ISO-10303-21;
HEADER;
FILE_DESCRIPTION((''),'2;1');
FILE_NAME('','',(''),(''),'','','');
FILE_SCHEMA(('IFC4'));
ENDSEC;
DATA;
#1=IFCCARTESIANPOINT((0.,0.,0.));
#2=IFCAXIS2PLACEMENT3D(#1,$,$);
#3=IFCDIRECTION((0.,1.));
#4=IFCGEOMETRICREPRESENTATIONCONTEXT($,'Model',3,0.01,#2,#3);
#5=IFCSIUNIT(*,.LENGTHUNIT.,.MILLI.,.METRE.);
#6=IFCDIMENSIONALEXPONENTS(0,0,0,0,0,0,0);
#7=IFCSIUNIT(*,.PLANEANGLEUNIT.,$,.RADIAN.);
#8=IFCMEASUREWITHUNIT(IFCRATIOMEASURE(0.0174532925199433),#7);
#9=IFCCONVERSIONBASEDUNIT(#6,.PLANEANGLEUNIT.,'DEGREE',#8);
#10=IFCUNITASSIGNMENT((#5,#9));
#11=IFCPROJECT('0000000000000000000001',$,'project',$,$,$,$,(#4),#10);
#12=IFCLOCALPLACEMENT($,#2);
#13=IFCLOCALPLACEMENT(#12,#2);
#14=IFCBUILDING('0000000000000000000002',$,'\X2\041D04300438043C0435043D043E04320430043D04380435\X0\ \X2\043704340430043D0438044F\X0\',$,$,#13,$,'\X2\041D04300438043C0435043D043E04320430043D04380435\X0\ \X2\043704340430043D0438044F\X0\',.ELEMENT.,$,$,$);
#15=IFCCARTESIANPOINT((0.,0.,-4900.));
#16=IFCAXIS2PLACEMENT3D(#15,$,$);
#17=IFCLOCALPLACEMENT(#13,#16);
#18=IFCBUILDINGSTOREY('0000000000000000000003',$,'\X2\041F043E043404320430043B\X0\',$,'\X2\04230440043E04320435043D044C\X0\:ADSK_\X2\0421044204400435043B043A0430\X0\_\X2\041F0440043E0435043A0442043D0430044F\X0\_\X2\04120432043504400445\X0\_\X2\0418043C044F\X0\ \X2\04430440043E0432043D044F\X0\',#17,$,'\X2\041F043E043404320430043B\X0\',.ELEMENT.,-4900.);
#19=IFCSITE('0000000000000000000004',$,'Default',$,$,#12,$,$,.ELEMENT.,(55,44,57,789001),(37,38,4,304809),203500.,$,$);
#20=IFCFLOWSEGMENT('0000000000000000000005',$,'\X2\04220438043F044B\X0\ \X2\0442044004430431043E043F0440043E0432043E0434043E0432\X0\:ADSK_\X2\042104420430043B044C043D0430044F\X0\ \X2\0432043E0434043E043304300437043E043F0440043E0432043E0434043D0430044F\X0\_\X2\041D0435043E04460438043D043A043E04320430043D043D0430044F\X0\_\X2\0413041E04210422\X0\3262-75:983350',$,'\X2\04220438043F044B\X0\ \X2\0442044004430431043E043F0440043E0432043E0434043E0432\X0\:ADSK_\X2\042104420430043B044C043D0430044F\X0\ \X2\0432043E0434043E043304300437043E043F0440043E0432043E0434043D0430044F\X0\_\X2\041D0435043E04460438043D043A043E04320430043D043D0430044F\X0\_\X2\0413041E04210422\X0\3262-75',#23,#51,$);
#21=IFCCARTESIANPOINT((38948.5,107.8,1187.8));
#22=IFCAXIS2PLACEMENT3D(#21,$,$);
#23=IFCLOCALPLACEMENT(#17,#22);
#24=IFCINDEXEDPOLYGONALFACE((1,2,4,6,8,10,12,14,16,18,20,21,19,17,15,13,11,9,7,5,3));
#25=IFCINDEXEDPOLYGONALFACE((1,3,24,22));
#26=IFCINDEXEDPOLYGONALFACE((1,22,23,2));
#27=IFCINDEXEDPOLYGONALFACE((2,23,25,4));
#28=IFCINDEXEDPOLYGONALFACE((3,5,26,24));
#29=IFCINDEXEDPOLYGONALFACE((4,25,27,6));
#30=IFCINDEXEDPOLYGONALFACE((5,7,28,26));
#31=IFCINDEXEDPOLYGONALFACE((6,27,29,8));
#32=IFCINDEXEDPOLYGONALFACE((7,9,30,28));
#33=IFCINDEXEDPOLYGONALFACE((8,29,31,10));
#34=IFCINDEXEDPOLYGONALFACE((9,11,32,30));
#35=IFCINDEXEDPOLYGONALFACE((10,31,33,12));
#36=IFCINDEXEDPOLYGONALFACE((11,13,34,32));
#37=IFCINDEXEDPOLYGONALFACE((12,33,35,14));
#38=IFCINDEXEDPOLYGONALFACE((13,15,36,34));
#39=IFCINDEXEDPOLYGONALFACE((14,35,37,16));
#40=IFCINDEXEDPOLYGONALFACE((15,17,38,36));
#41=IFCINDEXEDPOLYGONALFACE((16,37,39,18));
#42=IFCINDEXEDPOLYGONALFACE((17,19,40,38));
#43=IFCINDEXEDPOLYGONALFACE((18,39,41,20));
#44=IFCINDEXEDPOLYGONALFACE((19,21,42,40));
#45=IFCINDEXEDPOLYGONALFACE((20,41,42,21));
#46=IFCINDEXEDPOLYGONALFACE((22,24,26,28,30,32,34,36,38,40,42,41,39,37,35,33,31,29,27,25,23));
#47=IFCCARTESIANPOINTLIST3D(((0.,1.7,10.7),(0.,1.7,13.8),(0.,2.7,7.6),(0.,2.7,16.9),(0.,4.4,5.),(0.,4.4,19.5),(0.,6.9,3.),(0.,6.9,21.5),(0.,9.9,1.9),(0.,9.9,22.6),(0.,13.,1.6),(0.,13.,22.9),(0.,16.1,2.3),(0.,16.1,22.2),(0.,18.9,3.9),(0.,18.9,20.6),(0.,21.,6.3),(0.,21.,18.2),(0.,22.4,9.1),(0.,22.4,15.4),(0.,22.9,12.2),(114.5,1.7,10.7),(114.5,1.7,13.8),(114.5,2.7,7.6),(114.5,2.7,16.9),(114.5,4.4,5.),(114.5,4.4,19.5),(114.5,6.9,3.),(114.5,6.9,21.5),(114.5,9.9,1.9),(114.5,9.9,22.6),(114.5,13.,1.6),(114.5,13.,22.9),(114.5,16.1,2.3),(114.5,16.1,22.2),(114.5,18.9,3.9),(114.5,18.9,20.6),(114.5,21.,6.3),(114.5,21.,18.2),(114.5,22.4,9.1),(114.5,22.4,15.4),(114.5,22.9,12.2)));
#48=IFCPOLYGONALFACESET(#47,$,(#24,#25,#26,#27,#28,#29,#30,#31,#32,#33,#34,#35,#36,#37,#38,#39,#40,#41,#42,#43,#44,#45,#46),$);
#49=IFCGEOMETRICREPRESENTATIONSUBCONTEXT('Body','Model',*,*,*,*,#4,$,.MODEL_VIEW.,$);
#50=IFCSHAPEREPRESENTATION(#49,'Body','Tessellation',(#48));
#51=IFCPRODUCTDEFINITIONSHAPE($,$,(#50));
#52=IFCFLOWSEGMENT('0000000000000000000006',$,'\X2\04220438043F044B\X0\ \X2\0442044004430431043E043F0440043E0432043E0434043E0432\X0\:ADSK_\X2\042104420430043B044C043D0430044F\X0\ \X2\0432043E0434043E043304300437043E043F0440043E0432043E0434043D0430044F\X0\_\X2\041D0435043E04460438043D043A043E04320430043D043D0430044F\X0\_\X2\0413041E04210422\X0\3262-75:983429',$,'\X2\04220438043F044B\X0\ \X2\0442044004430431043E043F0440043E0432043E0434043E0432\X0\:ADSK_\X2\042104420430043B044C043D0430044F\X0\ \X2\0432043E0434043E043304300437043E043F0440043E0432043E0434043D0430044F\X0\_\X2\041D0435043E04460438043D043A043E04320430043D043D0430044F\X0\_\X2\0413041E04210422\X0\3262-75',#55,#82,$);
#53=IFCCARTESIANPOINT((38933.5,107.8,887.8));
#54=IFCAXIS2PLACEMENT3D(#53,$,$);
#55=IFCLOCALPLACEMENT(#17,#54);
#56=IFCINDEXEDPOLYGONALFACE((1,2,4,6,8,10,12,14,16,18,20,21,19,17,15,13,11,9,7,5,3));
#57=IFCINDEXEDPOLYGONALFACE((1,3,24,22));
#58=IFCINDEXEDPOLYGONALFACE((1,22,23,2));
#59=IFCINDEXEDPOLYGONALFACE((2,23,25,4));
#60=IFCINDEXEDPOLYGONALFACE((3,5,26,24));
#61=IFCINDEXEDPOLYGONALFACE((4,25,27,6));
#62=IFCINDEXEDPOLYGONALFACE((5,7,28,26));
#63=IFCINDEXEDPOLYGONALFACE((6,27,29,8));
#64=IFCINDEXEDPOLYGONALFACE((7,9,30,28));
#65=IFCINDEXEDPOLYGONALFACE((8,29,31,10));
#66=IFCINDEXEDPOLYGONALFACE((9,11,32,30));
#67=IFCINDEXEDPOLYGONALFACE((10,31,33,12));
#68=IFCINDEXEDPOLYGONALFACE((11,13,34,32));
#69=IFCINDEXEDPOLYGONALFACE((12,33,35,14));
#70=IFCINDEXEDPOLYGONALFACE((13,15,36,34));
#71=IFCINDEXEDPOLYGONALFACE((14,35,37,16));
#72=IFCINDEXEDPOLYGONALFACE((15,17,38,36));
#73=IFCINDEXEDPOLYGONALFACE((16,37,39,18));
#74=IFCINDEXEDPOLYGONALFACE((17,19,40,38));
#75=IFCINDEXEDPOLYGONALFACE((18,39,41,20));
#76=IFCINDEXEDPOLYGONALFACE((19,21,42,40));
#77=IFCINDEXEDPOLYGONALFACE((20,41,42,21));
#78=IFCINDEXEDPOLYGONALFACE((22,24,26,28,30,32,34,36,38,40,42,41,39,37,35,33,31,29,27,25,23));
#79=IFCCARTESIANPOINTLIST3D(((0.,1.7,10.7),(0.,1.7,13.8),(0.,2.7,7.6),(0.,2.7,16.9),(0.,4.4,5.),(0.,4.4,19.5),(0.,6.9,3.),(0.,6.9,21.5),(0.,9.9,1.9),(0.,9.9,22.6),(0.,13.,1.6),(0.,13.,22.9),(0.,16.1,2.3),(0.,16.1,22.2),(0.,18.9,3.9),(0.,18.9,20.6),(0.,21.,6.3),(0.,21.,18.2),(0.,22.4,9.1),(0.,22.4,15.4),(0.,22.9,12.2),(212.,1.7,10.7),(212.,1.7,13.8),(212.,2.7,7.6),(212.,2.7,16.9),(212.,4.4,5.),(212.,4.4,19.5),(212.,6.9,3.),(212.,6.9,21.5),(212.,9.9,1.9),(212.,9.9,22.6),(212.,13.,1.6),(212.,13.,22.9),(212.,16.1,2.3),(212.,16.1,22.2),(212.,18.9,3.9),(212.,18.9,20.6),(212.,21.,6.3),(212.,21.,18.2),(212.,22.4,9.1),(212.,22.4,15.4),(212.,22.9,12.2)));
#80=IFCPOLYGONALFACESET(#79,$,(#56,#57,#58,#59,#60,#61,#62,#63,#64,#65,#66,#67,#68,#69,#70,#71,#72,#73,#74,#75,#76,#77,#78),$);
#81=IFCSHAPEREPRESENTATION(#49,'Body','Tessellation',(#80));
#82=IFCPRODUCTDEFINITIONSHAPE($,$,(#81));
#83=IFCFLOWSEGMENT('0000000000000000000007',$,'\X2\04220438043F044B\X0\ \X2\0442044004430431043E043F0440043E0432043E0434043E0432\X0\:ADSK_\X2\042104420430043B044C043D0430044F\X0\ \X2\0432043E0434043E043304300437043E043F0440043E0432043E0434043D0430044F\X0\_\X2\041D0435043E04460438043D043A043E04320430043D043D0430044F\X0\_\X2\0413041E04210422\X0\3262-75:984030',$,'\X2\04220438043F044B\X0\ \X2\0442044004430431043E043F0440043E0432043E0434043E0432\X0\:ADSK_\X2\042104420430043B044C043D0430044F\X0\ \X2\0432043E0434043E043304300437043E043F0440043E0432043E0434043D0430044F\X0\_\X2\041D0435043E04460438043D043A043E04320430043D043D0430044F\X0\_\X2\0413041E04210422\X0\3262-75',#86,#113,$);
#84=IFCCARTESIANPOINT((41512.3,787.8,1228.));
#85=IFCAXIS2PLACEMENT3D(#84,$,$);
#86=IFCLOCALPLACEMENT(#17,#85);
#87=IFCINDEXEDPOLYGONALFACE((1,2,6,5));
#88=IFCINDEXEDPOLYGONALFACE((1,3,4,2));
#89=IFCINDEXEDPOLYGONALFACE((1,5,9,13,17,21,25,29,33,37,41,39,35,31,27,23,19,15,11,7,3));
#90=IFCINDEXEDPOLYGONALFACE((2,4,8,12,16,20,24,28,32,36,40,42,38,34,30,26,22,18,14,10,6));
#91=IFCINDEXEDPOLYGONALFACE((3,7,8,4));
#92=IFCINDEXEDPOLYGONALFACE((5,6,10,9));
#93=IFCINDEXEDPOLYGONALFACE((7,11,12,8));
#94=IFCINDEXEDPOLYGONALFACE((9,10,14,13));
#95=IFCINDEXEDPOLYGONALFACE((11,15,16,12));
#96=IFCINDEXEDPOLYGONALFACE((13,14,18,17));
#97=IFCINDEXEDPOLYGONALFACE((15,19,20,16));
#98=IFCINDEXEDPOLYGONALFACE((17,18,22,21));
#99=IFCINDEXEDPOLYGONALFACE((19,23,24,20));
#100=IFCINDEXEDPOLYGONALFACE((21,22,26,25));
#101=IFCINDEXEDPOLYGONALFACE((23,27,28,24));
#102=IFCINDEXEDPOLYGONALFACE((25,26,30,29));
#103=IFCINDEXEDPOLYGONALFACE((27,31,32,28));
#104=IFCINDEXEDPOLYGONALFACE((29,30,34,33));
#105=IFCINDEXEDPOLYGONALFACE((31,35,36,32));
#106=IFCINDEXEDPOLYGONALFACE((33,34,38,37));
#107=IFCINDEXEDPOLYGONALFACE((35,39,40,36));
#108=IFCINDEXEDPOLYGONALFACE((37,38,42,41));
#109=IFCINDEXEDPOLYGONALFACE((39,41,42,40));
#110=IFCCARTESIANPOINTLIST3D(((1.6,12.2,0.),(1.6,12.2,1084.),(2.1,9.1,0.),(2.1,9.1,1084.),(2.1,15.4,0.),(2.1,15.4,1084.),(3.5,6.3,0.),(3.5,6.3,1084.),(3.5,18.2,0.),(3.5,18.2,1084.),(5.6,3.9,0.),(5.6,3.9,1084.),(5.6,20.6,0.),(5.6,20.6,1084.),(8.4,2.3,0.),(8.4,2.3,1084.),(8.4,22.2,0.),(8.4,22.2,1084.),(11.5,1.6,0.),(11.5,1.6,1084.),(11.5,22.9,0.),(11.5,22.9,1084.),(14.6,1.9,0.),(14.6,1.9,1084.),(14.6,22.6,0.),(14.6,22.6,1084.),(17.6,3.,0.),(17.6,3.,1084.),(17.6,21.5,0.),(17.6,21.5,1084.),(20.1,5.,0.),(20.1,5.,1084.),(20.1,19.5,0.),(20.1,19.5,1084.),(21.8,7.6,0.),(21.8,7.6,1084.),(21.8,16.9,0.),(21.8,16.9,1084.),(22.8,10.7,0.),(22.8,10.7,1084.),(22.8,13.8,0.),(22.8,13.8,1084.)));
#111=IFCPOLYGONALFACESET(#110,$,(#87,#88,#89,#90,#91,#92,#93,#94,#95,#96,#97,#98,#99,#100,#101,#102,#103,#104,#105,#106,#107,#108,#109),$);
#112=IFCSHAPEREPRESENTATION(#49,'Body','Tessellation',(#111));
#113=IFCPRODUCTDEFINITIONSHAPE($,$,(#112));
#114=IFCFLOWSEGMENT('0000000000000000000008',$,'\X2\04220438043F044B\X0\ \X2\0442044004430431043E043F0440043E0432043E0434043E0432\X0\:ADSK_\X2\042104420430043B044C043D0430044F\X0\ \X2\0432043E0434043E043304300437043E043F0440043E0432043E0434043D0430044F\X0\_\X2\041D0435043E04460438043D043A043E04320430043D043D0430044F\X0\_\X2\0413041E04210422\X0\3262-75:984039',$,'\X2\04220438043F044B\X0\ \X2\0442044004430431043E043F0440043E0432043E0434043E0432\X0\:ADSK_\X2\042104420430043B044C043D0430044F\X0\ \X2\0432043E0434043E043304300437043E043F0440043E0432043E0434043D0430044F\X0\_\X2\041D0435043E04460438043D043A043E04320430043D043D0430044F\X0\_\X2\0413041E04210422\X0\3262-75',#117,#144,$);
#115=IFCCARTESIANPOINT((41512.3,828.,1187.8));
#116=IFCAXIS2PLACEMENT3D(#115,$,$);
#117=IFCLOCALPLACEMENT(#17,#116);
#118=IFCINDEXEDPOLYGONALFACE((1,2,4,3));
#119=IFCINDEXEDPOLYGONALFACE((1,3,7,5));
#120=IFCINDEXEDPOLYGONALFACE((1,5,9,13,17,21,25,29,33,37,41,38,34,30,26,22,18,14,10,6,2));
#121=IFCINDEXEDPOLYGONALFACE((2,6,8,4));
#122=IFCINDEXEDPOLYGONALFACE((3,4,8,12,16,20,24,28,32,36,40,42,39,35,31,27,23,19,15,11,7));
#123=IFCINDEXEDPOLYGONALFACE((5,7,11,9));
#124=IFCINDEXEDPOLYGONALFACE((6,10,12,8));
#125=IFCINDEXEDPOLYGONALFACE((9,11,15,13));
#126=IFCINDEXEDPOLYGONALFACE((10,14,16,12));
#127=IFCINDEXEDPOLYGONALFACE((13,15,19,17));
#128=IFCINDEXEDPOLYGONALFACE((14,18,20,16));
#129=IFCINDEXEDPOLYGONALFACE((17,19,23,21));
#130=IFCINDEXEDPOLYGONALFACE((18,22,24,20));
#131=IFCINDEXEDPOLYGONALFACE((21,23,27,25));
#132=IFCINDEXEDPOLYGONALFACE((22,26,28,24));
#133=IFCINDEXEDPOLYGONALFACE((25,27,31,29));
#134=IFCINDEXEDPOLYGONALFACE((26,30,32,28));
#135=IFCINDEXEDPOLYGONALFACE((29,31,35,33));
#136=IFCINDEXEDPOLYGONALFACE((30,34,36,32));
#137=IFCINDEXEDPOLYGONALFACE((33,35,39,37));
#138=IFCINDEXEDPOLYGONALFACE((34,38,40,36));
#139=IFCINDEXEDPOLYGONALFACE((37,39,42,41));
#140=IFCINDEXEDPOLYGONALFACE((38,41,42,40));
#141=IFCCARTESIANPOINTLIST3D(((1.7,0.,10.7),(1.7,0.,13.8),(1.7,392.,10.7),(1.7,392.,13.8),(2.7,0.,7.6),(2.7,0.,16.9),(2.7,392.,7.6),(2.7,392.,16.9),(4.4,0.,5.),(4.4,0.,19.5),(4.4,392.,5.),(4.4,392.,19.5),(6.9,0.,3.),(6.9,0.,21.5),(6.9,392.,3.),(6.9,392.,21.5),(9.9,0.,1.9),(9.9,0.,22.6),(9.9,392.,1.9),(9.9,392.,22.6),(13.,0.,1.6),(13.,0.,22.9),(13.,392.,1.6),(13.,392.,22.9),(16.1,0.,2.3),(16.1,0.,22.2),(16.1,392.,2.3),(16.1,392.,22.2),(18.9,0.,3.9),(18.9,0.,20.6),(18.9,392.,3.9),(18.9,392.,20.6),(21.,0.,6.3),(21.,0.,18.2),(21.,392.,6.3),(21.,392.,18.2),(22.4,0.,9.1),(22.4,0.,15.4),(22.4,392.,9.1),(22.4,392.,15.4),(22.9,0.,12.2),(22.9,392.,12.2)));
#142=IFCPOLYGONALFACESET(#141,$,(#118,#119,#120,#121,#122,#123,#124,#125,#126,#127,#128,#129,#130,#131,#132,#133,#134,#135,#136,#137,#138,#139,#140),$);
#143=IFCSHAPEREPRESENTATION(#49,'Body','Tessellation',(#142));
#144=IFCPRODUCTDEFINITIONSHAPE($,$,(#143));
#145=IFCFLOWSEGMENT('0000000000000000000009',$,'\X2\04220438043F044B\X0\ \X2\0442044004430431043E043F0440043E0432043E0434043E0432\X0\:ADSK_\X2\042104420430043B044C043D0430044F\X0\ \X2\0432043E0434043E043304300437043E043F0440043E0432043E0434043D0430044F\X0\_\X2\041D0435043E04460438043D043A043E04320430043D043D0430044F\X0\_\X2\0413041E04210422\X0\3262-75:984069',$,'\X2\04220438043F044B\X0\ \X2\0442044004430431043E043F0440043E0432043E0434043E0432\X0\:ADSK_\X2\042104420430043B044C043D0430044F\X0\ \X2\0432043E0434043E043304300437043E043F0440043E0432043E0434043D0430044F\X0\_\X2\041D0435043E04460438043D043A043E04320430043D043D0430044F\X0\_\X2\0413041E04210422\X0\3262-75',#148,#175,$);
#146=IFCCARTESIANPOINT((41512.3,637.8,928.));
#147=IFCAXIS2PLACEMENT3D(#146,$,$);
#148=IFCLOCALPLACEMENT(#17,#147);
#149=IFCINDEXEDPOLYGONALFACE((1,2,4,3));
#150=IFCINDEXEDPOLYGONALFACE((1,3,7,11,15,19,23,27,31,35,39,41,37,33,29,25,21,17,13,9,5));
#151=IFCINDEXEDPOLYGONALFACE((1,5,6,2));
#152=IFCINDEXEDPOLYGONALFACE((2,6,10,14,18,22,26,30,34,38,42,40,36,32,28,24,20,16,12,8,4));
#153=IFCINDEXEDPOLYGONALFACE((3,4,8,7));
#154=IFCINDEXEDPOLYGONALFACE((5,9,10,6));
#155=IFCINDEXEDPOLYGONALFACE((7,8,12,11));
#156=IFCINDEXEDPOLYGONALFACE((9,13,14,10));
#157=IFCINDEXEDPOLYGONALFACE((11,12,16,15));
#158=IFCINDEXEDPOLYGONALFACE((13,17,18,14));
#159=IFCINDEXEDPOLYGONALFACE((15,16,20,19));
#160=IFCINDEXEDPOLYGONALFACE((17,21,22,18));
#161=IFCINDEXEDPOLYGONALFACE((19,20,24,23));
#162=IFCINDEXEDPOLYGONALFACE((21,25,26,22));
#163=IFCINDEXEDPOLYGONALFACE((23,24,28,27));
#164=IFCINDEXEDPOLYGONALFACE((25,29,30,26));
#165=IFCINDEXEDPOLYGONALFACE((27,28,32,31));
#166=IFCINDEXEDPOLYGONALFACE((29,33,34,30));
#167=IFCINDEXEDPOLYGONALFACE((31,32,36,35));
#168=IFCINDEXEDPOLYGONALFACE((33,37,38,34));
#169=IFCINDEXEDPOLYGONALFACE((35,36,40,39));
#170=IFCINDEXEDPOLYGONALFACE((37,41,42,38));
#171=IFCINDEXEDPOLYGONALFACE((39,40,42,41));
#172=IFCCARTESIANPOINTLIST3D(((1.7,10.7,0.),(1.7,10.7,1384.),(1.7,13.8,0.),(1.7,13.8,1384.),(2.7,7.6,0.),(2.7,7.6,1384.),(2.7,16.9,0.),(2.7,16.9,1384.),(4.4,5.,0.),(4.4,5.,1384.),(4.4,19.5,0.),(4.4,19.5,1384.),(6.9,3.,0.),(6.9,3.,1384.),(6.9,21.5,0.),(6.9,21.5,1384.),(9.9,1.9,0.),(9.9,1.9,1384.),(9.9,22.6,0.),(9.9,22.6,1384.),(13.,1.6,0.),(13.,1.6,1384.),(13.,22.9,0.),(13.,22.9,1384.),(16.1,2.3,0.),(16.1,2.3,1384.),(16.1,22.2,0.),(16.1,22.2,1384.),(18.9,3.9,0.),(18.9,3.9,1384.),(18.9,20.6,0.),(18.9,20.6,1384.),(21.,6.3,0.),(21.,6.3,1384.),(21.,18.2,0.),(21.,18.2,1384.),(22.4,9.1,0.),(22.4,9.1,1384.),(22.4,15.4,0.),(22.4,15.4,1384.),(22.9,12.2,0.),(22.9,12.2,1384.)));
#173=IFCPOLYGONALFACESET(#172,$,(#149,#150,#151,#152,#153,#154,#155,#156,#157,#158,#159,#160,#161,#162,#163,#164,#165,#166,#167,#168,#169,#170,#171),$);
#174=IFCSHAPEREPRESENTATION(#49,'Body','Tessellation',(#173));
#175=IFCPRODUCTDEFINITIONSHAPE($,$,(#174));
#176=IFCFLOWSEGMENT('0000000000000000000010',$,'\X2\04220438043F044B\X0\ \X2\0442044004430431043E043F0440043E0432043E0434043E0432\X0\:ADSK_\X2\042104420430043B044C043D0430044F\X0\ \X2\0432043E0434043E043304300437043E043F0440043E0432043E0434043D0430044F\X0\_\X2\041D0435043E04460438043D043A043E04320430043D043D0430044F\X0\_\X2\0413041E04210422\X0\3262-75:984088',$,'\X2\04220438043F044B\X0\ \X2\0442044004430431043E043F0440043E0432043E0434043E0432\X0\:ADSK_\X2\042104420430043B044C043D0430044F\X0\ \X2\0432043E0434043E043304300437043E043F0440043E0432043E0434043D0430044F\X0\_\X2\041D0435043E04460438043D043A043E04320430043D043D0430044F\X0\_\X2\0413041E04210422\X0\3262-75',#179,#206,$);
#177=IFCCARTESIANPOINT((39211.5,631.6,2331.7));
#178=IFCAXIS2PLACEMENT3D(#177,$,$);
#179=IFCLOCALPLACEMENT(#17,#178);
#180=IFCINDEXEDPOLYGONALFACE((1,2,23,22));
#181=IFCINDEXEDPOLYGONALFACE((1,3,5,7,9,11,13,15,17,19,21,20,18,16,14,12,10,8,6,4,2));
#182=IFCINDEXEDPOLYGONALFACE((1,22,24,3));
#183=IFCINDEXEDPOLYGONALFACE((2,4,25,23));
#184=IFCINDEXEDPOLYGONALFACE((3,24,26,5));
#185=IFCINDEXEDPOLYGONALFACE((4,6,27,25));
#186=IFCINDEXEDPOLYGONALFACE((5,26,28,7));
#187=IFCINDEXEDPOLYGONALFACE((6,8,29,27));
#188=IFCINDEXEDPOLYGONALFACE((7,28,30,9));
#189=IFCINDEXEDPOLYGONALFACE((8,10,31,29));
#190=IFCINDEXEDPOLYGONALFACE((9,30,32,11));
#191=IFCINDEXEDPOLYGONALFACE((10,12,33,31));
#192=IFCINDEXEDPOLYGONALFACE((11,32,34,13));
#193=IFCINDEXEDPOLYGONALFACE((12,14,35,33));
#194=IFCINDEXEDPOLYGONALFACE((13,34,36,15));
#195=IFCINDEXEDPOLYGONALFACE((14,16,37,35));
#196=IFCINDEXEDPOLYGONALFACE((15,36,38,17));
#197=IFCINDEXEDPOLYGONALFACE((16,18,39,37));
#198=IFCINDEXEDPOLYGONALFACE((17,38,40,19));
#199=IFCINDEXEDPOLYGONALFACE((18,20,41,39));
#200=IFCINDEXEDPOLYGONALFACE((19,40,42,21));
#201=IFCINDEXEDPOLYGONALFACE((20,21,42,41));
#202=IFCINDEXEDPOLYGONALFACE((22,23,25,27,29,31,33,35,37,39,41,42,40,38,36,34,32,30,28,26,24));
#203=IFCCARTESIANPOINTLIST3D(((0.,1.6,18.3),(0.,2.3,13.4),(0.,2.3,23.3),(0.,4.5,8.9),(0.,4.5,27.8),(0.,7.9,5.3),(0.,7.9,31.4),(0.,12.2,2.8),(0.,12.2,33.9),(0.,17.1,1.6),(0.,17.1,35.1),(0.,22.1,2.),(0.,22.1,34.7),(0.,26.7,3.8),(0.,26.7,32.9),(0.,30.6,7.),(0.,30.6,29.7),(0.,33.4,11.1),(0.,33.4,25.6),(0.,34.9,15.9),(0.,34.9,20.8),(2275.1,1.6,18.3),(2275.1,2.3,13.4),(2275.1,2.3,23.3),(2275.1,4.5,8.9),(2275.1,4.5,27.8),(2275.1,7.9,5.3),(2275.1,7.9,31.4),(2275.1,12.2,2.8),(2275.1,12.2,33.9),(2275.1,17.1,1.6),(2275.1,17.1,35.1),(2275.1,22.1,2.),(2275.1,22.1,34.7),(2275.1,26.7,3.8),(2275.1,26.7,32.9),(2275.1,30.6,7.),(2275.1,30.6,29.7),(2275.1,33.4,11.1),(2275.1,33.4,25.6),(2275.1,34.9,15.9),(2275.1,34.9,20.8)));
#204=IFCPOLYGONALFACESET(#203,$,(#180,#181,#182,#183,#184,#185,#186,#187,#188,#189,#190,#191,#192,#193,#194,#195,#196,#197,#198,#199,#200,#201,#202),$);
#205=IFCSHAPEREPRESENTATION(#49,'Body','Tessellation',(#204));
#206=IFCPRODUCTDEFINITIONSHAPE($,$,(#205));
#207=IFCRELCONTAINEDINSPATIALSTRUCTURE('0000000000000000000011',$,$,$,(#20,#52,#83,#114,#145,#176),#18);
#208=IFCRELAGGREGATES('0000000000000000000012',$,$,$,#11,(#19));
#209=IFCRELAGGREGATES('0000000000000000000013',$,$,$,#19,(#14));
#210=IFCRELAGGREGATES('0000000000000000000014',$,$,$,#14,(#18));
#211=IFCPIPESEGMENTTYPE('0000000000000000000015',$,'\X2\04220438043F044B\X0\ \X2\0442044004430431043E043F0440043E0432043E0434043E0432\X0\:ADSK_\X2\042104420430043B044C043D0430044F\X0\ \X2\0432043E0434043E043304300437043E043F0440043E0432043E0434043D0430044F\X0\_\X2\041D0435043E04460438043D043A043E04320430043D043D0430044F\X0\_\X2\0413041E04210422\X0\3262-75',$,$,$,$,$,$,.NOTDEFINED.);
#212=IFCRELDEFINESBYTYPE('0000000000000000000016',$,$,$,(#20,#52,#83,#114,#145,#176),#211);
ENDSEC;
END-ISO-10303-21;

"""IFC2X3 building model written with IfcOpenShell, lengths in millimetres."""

from ifc_helpers import new_model, entity, si_unit, converted_unit, direction, frame, origin, origin_2d_with_axis, place, context, subcontext, project, spatial, circle, extrude, type_object, element, save


model = new_model("IFC2X3")

# Units and contexts
model_context = context("Model", 3, precision=0.01, world=origin(), true_north=direction((0.0, 1.0)))
body_context = subcontext(model_context, "Body", "Model", "MODEL_VIEW")
ifc_project = project(units=[si_unit("LENGTHUNIT", "METRE", prefix="MILLI"), converted_unit("PLANEANGLEUNIT", "DEGREE", entity("IfcRatioMeasure", 0.0174532925199433), si_unit("PLANEANGLEUNIT", "RADIAN"), dimensions=[0, 0, 0, 0, 0, 0, 0])], contexts=[model_context])

# Site, building, storey
site_placement = place(None, origin())
site = spatial("IfcSite", under=ifc_project, at=site_placement, Name="Default", CompositionType="ELEMENT", RefLatitude=(55, 44, 57, 789001), RefLongitude=(37, 38, 4, 304809), RefElevation=203500.0)
building_placement = place(site_placement, origin())
building = spatial("IfcBuilding", under=site, at=building_placement, Name="Наименование здания", LongName="Наименование здания", CompositionType="ELEMENT")
storey_placement = place(building_placement, frame((0.0, 0.0, -4900.0)))
storey = spatial("IfcBuildingStorey", under=building, at=storey_placement, Name="Подвал", ObjectType="Уровень:ADSK_Стрелка_Проектная_Вверх_Имя уровня", LongName="Подвал", CompositionType="ELEMENT", Elevation=-4900.0)

# Flow segments
pipe_segment_type = type_object("IfcPipeSegmentType", Name="Типы трубопроводов:ADSK_Стальная водогазопроводная_Неоцинкованная_ГОСТ3262-75", PredefinedType="NOTDEFINED")
flow_segment_1_placement = place(storey_placement, frame((38948.5, 107.8, 1187.8)))
element("IfcFlowSegment", 1, at=flow_segment_1_placement, inside=storey, type_object=pipe_segment_type, Name="Типы трубопроводов:ADSK_Стальная водогазопроводная_Неоцинкованная_ГОСТ3262-75:983350", ObjectType="Типы трубопроводов:ADSK_Стальная водогазопроводная_Неоцинкованная_ГОСТ3262-75", context=body_context, shape_type="SweptSolid", body=[
    extrude(circle(Radius=10.7, at=origin_2d_with_axis()), frame((0.0, 12.2, 12.2), z_axis=(1.0, 0.0, 0.0), x_axis=(0.0, 1.0, 0.0)), (0.0, 0.0, 1.0), 114.5),
])
flow_segment_2_placement = place(storey_placement, frame((38933.5, 107.8, 887.8)))
element("IfcFlowSegment", 2, at=flow_segment_2_placement, inside=storey, type_object=pipe_segment_type, Name="Типы трубопроводов:ADSK_Стальная водогазопроводная_Неоцинкованная_ГОСТ3262-75:983429", ObjectType="Типы трубопроводов:ADSK_Стальная водогазопроводная_Неоцинкованная_ГОСТ3262-75", context=body_context, shape_type="SweptSolid", body=[
    extrude(circle(Radius=10.7, at=origin_2d_with_axis()), frame((0.0, 12.2, 12.2), z_axis=(1.0, 0.0, 0.0), x_axis=(0.0, 1.0, 0.0)), (0.0, 0.0, 1.0), 212.0),
])
flow_segment_3_placement = place(storey_placement, frame((41512.3, 787.8, 1228.0)))
element("IfcFlowSegment", 3, at=flow_segment_3_placement, inside=storey, type_object=pipe_segment_type, Name="Типы трубопроводов:ADSK_Стальная водогазопроводная_Неоцинкованная_ГОСТ3262-75:984030", ObjectType="Типы трубопроводов:ADSK_Стальная водогазопроводная_Неоцинкованная_ГОСТ3262-75", context=body_context, shape_type="SweptSolid", body=[
    extrude(circle(Radius=10.7, at=origin_2d_with_axis()), frame((12.2, 12.2, 0.0), z_axis=(0.0, 0.0, 1.0), x_axis=(-1.0, 0.0, 0.0)), (0.0, 0.0, 1.0), 1084.0),
])
flow_segment_4_placement = place(storey_placement, frame((41512.3, 828.0, 1187.8)))
element("IfcFlowSegment", 4, at=flow_segment_4_placement, inside=storey, type_object=pipe_segment_type, Name="Типы трубопроводов:ADSK_Стальная водогазопроводная_Неоцинкованная_ГОСТ3262-75:984039", ObjectType="Типы трубопроводов:ADSK_Стальная водогазопроводная_Неоцинкованная_ГОСТ3262-75", context=body_context, shape_type="SweptSolid", body=[
    extrude(circle(Radius=10.7, at=origin_2d_with_axis()), frame((12.2, 0.0, 12.2), z_axis=(0.0, 1.0, 0.0), x_axis=(1.0, 0.0, 0.0)), (0.0, 0.0, 1.0), 392.0),
])
flow_segment_5_placement = place(storey_placement, frame((41512.3, 637.8, 928.0)))
element("IfcFlowSegment", 5, at=flow_segment_5_placement, inside=storey, type_object=pipe_segment_type, Name="Типы трубопроводов:ADSK_Стальная водогазопроводная_Неоцинкованная_ГОСТ3262-75:984069", ObjectType="Типы трубопроводов:ADSK_Стальная водогазопроводная_Неоцинкованная_ГОСТ3262-75", context=body_context, shape_type="SweptSolid", body=[
    extrude(circle(Radius=10.7, at=origin_2d_with_axis()), frame((12.2, 12.2, 0.0)), (0.0, 0.0, 1.0), 1384.0),
])
flow_segment_6_placement = place(storey_placement, frame((39211.5, 631.6, 2331.7)))
element("IfcFlowSegment", 6, at=flow_segment_6_placement, inside=storey, type_object=pipe_segment_type, Name="Типы трубопроводов:ADSK_Стальная водогазопроводная_Неоцинкованная_ГОСТ3262-75:984088", ObjectType="Типы трубопроводов:ADSK_Стальная водогазопроводная_Неоцинкованная_ГОСТ3262-75", context=body_context, shape_type="SweptSolid", body=[
    extrude(circle(Radius=16.8, at=origin_2d_with_axis()), frame((0.0, 18.4, 18.4), z_axis=(1.0, 0.0, 0.0), x_axis=(0.0, -1.0, 0.0)), (0.0, 0.0, 1.0), 2275.1),
])

save(model, "model.ifc")
